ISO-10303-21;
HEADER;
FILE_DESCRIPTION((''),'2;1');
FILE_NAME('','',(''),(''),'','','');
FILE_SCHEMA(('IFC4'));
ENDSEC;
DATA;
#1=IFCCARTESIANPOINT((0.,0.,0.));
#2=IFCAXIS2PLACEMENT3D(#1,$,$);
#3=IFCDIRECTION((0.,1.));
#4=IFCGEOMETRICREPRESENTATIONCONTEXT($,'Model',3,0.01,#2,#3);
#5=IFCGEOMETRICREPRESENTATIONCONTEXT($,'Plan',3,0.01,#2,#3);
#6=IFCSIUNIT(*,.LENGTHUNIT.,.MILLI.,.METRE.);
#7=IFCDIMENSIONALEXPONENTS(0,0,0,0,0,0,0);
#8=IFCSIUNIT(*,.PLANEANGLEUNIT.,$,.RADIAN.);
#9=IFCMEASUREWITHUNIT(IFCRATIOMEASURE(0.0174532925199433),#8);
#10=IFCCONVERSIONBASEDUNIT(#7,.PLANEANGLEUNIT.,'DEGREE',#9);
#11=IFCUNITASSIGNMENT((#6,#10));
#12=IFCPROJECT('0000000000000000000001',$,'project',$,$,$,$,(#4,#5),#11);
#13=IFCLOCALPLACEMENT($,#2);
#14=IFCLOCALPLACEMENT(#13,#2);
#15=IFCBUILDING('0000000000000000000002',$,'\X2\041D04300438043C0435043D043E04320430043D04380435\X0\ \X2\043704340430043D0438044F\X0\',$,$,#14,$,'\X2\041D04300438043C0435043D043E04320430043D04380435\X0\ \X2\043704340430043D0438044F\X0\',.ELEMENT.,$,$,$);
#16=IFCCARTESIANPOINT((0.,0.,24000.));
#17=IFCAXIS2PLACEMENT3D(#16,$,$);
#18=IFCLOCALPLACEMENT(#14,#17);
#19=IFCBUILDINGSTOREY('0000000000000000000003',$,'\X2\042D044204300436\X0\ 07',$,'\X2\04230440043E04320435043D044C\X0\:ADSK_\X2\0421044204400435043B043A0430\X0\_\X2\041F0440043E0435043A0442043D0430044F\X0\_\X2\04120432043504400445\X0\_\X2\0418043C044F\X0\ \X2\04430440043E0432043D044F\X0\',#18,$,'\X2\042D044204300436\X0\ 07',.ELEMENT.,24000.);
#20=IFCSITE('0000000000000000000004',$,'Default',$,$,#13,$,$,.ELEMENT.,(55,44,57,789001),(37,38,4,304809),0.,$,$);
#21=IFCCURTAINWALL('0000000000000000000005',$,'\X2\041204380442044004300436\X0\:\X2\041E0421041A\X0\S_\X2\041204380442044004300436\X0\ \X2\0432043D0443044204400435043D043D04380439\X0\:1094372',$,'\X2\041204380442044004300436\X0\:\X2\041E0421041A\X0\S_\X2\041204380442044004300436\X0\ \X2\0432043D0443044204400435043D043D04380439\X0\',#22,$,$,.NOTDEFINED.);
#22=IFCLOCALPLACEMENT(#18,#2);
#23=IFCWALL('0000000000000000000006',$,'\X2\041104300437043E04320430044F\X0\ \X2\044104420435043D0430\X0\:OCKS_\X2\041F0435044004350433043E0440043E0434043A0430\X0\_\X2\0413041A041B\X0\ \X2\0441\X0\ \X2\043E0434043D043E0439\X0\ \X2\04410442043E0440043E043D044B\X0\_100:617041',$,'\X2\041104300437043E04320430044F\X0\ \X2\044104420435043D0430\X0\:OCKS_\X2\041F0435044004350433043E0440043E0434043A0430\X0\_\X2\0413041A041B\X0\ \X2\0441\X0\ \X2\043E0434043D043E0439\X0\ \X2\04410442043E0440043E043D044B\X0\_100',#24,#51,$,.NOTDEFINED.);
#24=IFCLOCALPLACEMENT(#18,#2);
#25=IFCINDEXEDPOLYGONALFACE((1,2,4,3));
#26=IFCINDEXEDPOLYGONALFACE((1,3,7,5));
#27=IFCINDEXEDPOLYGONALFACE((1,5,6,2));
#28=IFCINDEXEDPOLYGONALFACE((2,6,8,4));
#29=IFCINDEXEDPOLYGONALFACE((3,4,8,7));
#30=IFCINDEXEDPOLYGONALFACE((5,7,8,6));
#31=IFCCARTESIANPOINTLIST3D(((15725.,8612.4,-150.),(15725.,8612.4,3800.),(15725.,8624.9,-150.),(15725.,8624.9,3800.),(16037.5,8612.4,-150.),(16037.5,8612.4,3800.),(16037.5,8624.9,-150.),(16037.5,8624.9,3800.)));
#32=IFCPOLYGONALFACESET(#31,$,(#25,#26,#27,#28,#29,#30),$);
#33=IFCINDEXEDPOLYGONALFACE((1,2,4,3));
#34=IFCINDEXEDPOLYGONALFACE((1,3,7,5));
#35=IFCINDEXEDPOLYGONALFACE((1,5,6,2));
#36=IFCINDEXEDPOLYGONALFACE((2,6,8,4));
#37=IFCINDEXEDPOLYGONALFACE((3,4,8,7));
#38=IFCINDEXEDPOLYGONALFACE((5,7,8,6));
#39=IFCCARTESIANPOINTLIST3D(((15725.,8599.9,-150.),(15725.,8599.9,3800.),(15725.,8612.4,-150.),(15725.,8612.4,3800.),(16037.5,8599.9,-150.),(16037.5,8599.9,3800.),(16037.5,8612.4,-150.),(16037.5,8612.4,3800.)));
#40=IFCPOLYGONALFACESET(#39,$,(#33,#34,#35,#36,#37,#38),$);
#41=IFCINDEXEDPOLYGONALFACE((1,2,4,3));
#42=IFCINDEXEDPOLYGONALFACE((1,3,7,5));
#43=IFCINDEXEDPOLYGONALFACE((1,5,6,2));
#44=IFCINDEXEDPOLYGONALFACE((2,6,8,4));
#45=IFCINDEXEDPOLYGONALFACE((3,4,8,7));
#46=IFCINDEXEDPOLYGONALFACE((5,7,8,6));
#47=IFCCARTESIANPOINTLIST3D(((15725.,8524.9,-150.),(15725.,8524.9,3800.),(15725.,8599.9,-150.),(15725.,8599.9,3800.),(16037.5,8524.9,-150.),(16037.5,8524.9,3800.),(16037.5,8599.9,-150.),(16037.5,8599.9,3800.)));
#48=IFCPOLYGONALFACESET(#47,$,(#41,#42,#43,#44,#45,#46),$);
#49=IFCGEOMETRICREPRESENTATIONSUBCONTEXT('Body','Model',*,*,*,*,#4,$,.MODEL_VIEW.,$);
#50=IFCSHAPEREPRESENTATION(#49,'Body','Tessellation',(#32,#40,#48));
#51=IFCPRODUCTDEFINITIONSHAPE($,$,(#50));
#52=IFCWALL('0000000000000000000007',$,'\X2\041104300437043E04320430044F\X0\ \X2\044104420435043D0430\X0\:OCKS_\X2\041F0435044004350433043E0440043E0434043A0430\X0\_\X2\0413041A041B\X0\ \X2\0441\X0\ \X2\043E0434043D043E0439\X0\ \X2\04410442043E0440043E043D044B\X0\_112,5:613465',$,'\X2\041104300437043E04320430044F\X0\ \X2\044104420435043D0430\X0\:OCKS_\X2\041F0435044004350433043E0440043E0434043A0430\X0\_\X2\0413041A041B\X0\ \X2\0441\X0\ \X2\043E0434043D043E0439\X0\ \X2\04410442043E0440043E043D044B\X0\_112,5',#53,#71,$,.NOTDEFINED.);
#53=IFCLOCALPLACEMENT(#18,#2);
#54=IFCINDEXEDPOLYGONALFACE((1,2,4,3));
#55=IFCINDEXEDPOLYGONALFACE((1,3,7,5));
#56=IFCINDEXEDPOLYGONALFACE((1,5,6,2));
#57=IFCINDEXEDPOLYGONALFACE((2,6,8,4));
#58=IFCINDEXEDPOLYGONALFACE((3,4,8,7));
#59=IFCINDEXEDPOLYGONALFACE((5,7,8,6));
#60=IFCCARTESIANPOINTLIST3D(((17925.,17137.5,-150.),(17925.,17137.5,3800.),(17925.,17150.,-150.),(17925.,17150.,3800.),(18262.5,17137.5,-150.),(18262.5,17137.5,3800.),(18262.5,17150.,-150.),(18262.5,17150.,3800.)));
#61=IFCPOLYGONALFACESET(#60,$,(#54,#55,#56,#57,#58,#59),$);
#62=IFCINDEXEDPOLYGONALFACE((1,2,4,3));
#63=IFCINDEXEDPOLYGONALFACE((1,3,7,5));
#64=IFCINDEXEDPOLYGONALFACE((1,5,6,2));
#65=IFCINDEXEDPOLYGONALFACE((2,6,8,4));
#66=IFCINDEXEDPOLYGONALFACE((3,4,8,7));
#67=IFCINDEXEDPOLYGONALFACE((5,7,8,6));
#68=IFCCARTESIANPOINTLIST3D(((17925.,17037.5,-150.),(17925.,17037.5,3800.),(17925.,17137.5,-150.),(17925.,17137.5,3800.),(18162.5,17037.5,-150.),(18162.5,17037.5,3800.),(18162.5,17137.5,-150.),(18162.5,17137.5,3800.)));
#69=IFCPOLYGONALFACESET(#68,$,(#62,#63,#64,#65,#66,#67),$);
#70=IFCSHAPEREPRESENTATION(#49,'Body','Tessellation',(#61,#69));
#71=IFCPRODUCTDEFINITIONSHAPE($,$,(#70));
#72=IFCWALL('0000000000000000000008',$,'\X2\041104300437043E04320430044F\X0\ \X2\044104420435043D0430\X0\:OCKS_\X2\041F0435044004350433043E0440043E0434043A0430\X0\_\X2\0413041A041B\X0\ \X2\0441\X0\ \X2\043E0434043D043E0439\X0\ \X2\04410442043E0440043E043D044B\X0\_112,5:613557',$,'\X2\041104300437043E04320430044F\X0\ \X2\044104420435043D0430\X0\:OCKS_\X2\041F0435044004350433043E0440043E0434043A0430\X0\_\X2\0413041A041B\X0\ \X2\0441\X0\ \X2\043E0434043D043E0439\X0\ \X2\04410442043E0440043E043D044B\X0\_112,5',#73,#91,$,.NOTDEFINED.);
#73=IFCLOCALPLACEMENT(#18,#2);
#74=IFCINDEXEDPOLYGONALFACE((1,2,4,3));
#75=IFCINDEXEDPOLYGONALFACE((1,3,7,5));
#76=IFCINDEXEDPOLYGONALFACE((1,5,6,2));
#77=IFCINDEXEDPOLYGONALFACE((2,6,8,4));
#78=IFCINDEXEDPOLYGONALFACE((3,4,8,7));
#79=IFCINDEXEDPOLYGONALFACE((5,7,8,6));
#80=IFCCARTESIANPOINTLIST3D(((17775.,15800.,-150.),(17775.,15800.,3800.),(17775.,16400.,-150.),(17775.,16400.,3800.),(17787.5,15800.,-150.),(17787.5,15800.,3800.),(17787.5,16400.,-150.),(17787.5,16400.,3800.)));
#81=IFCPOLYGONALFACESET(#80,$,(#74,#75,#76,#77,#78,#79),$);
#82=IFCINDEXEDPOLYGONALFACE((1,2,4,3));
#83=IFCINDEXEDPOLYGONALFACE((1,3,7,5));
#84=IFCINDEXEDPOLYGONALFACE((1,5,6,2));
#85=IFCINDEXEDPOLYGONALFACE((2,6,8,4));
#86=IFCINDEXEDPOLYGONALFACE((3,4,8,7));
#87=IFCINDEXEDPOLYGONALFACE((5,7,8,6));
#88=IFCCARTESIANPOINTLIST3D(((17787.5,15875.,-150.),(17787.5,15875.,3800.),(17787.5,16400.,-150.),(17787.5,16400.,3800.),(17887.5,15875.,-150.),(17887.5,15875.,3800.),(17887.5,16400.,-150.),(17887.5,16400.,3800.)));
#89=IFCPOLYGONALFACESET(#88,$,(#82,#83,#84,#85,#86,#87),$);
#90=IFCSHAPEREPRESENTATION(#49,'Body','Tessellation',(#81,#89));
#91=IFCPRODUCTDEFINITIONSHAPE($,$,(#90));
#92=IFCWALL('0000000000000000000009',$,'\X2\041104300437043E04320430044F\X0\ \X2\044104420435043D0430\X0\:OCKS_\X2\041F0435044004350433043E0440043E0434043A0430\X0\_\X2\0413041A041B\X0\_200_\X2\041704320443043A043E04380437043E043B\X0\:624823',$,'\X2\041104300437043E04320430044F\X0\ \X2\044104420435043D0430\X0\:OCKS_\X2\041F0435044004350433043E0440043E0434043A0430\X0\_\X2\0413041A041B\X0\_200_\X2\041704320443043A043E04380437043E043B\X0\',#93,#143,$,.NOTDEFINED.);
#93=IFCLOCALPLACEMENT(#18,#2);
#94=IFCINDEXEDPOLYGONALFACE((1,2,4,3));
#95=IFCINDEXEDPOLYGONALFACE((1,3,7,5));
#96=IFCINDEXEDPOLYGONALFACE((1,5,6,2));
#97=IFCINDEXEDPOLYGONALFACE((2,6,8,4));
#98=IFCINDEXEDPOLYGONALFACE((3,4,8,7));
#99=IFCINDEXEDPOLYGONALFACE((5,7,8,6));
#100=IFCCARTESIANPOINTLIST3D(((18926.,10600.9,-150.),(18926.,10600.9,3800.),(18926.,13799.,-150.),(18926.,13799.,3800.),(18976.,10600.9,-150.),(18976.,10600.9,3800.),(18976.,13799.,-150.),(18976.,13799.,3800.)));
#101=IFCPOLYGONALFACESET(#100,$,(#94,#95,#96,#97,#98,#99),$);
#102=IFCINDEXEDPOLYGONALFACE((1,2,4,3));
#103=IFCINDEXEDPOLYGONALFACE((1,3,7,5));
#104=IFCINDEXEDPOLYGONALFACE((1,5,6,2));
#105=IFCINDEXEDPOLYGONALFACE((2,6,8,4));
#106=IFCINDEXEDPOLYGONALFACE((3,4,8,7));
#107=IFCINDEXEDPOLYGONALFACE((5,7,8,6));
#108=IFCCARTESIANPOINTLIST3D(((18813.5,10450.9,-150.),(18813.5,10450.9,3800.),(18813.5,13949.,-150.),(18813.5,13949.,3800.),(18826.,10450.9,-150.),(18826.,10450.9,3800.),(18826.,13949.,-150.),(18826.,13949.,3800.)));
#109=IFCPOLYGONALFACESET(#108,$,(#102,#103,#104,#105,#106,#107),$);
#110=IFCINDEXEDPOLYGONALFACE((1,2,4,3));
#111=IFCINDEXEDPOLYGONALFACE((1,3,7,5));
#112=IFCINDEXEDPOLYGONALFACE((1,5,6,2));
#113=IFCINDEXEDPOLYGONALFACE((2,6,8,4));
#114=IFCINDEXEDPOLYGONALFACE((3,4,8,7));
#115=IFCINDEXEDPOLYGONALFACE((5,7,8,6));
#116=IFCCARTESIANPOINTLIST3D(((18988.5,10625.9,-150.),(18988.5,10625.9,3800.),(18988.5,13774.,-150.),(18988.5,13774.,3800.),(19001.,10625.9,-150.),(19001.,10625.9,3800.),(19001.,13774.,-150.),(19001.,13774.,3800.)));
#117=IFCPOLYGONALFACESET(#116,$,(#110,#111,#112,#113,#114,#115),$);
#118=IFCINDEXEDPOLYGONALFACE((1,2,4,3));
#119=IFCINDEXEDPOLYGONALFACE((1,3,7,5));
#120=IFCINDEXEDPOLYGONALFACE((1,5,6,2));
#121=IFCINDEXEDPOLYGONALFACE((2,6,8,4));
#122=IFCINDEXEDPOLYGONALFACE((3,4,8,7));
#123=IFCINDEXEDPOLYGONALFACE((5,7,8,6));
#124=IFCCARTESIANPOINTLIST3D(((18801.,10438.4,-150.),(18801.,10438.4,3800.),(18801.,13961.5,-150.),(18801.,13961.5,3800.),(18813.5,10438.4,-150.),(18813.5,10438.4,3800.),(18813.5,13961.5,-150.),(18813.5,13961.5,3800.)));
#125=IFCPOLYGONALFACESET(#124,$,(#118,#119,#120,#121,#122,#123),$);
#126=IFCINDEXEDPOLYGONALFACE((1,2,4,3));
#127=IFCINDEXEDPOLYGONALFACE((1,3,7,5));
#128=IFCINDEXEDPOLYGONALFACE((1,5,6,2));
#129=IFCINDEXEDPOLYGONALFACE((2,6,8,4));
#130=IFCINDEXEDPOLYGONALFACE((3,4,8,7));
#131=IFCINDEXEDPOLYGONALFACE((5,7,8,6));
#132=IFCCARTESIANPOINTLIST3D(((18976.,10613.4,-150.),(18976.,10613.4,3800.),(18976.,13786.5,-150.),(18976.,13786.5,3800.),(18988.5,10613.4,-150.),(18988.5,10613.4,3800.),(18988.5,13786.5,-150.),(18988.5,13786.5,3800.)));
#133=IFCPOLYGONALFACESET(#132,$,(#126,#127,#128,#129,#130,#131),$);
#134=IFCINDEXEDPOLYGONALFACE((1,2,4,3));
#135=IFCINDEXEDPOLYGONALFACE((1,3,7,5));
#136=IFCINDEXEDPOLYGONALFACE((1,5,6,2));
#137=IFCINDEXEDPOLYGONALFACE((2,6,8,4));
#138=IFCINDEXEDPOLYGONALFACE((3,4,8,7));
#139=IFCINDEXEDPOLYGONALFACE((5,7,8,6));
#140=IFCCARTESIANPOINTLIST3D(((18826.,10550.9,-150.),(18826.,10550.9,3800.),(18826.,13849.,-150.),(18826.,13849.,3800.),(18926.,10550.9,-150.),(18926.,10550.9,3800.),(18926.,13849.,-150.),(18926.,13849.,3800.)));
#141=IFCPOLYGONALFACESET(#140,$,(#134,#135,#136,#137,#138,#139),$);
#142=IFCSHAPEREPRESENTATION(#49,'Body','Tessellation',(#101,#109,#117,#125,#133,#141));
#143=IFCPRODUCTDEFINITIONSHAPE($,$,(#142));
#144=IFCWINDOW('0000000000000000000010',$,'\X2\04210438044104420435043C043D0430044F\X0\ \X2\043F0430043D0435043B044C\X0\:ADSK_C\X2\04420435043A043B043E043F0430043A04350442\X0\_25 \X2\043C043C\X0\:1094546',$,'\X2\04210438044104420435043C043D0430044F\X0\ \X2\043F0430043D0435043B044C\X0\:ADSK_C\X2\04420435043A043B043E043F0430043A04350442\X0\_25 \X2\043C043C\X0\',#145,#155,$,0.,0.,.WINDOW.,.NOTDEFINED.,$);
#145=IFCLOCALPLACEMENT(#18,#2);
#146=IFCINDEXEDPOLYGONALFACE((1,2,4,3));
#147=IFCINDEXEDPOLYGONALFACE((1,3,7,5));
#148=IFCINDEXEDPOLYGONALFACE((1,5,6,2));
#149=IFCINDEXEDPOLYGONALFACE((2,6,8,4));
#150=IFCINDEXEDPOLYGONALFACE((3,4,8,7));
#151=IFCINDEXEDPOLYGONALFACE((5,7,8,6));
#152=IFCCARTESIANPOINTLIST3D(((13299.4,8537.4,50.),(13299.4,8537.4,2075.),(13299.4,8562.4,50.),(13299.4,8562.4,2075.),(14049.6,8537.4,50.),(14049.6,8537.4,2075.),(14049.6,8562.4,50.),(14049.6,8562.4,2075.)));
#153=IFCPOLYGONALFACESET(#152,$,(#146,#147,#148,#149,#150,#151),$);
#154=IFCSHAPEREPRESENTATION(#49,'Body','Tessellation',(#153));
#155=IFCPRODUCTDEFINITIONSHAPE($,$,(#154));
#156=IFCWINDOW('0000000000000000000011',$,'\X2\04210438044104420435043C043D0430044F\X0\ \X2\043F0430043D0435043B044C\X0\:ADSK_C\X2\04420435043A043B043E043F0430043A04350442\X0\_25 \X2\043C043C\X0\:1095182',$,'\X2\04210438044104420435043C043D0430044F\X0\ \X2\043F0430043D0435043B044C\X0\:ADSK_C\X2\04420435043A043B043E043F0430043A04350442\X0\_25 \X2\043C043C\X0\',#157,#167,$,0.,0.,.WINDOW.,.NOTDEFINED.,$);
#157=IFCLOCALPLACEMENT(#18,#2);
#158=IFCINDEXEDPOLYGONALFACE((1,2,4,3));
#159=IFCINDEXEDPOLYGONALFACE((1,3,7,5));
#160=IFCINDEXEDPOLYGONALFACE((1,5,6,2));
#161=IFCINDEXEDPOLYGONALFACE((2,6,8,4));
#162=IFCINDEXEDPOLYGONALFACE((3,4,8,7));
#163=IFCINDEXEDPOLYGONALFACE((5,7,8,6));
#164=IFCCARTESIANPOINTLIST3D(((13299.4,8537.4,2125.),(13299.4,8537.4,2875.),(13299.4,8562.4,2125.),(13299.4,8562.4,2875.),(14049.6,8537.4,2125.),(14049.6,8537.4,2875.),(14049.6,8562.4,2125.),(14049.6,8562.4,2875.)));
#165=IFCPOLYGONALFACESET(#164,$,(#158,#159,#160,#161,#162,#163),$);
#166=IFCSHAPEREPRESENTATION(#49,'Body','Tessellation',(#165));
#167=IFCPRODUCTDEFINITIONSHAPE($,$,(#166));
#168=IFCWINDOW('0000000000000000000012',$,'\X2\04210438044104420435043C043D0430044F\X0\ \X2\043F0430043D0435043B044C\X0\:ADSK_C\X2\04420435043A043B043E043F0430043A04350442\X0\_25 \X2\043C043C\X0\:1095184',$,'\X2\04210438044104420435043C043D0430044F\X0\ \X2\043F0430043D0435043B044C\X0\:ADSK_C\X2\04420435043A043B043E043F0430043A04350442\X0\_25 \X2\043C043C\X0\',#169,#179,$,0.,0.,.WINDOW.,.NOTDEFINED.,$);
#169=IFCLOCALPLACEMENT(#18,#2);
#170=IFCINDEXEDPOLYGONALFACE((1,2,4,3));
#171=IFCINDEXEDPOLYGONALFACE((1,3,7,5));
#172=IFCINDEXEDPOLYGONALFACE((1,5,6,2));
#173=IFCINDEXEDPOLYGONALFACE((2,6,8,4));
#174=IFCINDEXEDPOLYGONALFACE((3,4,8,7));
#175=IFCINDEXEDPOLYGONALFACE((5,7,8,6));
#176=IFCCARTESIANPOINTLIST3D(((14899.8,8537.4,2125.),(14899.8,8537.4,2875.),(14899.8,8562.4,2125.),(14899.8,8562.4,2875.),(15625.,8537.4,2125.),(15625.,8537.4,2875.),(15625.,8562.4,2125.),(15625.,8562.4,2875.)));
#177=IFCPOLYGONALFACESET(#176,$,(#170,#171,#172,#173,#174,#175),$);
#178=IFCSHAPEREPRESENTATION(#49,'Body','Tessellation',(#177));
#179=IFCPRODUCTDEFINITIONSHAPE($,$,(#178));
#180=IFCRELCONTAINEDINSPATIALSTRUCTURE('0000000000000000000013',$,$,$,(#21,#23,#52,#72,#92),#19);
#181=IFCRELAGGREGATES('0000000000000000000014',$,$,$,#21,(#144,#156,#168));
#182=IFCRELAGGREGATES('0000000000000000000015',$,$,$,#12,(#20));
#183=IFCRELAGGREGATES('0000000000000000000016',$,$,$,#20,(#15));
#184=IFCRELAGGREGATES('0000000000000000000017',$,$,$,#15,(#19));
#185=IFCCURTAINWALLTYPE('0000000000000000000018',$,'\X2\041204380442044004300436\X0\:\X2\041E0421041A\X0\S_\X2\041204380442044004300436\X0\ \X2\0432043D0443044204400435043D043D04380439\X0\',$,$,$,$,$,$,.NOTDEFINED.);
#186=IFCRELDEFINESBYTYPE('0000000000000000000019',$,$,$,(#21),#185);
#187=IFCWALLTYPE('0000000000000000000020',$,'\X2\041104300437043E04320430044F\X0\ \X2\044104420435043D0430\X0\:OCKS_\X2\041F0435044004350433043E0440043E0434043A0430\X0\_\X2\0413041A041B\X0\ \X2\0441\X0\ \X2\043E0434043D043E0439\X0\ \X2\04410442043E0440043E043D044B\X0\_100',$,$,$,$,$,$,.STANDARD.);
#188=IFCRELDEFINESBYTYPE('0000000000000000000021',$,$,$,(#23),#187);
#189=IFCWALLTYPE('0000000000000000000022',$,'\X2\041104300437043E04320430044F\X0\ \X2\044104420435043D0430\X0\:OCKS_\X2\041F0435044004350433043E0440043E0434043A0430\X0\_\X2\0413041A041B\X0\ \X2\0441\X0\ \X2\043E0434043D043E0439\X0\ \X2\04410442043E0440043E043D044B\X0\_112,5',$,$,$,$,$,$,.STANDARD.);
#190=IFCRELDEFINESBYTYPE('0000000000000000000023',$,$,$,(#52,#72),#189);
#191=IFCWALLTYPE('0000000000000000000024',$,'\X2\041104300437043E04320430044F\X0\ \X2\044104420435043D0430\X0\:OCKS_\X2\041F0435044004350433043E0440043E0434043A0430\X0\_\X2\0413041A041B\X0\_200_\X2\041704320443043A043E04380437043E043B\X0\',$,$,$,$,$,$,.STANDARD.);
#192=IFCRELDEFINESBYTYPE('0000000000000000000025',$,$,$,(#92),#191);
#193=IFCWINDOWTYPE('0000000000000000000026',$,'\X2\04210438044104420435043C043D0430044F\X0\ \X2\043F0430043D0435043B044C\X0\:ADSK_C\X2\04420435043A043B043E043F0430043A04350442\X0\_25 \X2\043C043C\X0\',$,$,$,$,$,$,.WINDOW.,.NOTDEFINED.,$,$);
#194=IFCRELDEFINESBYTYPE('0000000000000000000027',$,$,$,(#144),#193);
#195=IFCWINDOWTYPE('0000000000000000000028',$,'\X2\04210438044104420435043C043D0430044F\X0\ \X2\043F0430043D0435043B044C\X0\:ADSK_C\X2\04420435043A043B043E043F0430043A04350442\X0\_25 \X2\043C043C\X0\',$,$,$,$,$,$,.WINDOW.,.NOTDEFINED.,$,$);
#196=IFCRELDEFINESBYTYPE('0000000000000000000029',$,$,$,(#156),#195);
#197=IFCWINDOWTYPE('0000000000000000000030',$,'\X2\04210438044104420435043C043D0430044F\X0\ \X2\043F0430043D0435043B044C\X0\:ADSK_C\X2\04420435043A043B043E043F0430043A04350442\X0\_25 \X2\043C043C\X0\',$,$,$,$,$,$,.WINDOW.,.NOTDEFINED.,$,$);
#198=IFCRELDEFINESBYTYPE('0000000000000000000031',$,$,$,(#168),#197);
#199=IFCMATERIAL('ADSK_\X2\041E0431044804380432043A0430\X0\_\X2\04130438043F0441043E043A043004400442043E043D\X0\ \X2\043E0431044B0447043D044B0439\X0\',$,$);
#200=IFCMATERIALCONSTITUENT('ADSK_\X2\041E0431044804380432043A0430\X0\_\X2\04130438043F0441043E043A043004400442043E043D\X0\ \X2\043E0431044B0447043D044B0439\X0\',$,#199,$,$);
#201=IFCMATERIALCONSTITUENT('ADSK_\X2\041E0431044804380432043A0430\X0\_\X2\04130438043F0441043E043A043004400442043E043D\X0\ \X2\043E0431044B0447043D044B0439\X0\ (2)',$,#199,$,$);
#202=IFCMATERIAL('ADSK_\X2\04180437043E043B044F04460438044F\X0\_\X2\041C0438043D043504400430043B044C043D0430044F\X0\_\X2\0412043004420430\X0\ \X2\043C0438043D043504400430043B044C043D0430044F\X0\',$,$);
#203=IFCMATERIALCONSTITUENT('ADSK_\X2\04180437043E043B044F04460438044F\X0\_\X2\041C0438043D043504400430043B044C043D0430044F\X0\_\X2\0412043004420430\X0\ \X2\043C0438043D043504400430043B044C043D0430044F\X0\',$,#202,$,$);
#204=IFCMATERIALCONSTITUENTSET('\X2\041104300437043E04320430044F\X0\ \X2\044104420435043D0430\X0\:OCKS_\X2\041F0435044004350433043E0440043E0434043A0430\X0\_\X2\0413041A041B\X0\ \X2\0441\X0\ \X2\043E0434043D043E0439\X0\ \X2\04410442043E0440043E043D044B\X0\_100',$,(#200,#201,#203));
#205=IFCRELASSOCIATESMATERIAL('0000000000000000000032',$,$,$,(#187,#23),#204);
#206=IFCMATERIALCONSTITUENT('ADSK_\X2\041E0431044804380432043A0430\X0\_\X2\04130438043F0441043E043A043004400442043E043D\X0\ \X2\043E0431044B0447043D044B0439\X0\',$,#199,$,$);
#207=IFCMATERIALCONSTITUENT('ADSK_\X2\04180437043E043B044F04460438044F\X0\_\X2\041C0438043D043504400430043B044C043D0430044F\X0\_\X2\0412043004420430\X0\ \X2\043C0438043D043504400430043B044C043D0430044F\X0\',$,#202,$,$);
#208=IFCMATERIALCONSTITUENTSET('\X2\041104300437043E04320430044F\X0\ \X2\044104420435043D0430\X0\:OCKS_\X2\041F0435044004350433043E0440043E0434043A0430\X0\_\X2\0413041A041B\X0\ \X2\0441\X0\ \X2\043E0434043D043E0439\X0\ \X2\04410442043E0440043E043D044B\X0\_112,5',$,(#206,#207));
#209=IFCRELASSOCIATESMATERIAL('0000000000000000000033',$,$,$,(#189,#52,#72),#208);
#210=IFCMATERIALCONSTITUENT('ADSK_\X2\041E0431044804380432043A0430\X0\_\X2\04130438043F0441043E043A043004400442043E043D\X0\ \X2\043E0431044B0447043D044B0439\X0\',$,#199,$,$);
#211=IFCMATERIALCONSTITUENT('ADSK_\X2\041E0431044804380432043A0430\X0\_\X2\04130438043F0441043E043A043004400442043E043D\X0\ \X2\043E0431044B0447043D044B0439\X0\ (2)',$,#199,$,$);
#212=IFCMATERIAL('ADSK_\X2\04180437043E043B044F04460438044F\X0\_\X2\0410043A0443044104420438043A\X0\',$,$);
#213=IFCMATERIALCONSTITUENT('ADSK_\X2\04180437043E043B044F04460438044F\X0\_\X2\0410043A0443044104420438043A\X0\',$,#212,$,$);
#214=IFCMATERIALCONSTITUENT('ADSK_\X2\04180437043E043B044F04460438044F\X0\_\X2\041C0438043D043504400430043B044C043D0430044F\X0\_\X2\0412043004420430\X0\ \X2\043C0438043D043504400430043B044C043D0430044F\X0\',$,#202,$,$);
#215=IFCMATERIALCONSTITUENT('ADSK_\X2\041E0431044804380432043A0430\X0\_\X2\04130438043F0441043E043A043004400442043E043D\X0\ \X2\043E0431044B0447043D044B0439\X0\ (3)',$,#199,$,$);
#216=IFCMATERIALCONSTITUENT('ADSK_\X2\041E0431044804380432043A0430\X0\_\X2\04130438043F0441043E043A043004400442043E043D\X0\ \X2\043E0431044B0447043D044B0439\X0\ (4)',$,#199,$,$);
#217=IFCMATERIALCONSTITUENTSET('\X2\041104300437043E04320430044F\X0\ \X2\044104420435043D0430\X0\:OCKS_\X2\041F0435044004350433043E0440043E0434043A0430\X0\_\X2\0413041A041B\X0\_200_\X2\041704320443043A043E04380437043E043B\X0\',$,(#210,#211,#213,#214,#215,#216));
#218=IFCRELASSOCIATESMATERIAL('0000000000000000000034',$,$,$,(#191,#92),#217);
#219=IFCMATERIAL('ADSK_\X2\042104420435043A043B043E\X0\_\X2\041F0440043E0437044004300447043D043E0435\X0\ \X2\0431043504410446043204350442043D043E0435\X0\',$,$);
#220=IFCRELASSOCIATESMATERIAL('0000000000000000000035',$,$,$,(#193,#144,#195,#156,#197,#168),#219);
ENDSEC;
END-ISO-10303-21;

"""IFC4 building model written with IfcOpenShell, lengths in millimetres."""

from ifc_helpers import new_model, entity, si_unit, converted_unit, direction, frame, origin, place, context, subcontext, project, spatial, indexed_curve, outline, extrude, source, transform, mapped, material, constituent, constituent_set, type_object, type_shapes, element, aggregate, save


model = new_model("IFC4")

# Units and contexts
model_context = context("Model", 3, precision=0.01, world=origin(), true_north=direction((0.0, 1.0)))
plan_context = context("Plan", 3, precision=0.01, world=origin(), true_north=direction((0.0, 1.0)))
body_context = subcontext(model_context, "Body", "Model", "MODEL_VIEW")
ifc_project = project(units=[si_unit("LENGTHUNIT", "METRE", prefix="MILLI"), converted_unit("PLANEANGLEUNIT", "DEGREE", entity("IfcRatioMeasure", 0.0174532925199433), si_unit("PLANEANGLEUNIT", "RADIAN"), dimensions=[0, 0, 0, 0, 0, 0, 0])], contexts=[model_context, plan_context])

# Site, building, storey
site_placement = place(None, frame((0.0, 0.0, 0.0)))
site = spatial("IfcSite", under=ifc_project, at=site_placement, Name="Default", CompositionType="ELEMENT", RefLatitude=(55, 44, 57, 789001), RefLongitude=(37, 38, 4, 304809), RefElevation=0.0)
building_placement = place(site_placement, origin())
building = spatial("IfcBuilding", under=site, at=building_placement, Name="Наименование здания", LongName="Наименование здания", CompositionType="ELEMENT")
storey_placement = place(building_placement, frame((0.0, 0.0, 24000.0)))
storey = spatial("IfcBuildingStorey", under=building, at=storey_placement, Name="Этаж 07", ObjectType="Уровень:ADSK_Стрелка_Проектная_Вверх_Имя уровня", LongName="Этаж 07", CompositionType="ELEMENT", Elevation=24000.0)

# Curtain wall
curtain_wall_type = type_object("IfcCurtainWallType", Name="Витраж:ОСКS_Витраж внутренний", PredefinedType="NOTDEFINED")
curtain_wall_placement = place(storey_placement, frame((0.0, 0.0, -24000.0)))
curtain_wall = element("IfcCurtainWall", 1, at=curtain_wall_placement, inside=storey, type_object=curtain_wall_type, Name="Витраж:ОСКS_Витраж внутренний:1094372", ObjectType="Витраж:ОСКS_Витраж внутренний", PredefinedType="NOTDEFINED")

# Shared definitions
ifc_material_1 = material(Name="ADSK_Обшивка_Гипсокартон обычный")
ifc_material_2 = material(Name="ADSK_Изоляция_Минеральная_Вата минеральная")

# Walls
ifc_constituent_1 = constituent(ifc_material_1, Name="ADSK_Обшивка_Гипсокартон обычный")
ifc_constituent_2 = constituent(ifc_material_1, Name="ADSK_Обшивка_Гипсокартон обычный (2)")
ifc_constituent_3 = constituent(ifc_material_2, Name="ADSK_Изоляция_Минеральная_Вата минеральная")
ifc_constituent_set_1 = constituent_set(constituents=[ifc_constituent_1, ifc_constituent_2, ifc_constituent_3], Name="Базовая стена:OCKS_Перегородка_ГКЛ с одной стороны_100")
wall_type_1 = type_object("IfcWallType", Name="Базовая стена:OCKS_Перегородка_ГКЛ с одной стороны_100", PredefinedType="STANDARD", material=ifc_constituent_set_1)
wall_1_placement = place(storey_placement, frame((15725.0, 8574.9, -150.0)))
element("IfcWall", 2, at=wall_1_placement, inside=storey, type_object=wall_type_1, material=ifc_constituent_set_1, Name="Базовая стена:OCKS_Перегородка_ГКЛ с одной стороны_100:617041", ObjectType="Базовая стена:OCKS_Перегородка_ГКЛ с одной стороны_100", PredefinedType="NOTDEFINED", context=body_context, shape_type="SweptSolid", body=[
    extrude(outline(indexed_curve([(-6.3, -156.3), (6.2, -156.3), (6.2, 156.3), (-6.2, 156.3), (-6.3, -156.3)], self_intersect=False)), frame((156.3, 43.7, 0.0), z_axis=(0.0, 0.0, 1.0), x_axis=(0.0, -1.0, 0.0)), (0.0, 0.0, 1.0), 3950.0),
    extrude(outline(indexed_curve([(-156.3, -6.3), (156.3, -6.3), (156.3, 6.3), (-156.3, 6.3), (-156.3, -6.3)], self_intersect=False)), frame((156.3, 31.3, 0.0)), (0.0, 0.0, 1.0), 3950.0),
    extrude(outline(indexed_curve([(-37.5, -156.3), (37.5, -156.3), (37.5, 156.3), (-37.5, 156.3), (-37.5, -156.3)], self_intersect=False)), frame((156.3, -12.5, 0.0), z_axis=(0.0, 0.0, 1.0), x_axis=(0.0, 1.0, 0.0)), (0.0, 0.0, 1.0), 3950.0),
])
ifc_constituent_4 = constituent(ifc_material_1, Name="ADSK_Обшивка_Гипсокартон обычный")
ifc_constituent_5 = constituent(ifc_material_2, Name="ADSK_Изоляция_Минеральная_Вата минеральная")
ifc_constituent_set_2 = constituent_set(constituents=[ifc_constituent_4, ifc_constituent_5], Name="Базовая стена:OCKS_Перегородка_ГКЛ с одной стороны_112,5")
wall_type_2 = type_object("IfcWallType", Name="Базовая стена:OCKS_Перегородка_ГКЛ с одной стороны_112,5", PredefinedType="STANDARD", material=ifc_constituent_set_2)
wall_2_placement = place(storey_placement, frame((18162.5, 17093.7, -150.0), z_axis=(0.0, 0.0, 1.0), x_axis=(-1.0, 0.0, 0.0)))
element("IfcWall", 3, at=wall_2_placement, inside=storey, type_object=wall_type_2, material=ifc_constituent_set_2, Name="Базовая стена:OCKS_Перегородка_ГКЛ с одной стороны_112,5:613465", ObjectType="Базовая стена:OCKS_Перегородка_ГКЛ с одной стороны_112,5", PredefinedType="NOTDEFINED", context=body_context, shape_type="SweptSolid", body=[
    extrude(outline(indexed_curve([(-6.2, -168.7), (6.3, -168.7), (6.3, 168.7), (-6.2, 168.7), (-6.2, -168.7)], self_intersect=False)), frame((68.7, -50.0, 0.0), z_axis=(0.0, 0.0, 1.0), x_axis=(0.0, 1.0, 0.0)), (0.0, 0.0, 1.0), 3950.0),
    extrude(outline(indexed_curve([(-50.0, -118.7), (50.0, -118.7), (50.0, 118.7), (-50.0, 118.7), (-50.0, -118.7)], self_intersect=False)), frame((118.7, 6.2, 0.0), z_axis=(0.0, 0.0, 1.0), x_axis=(0.0, -1.0, 0.0)), (0.0, 0.0, 1.0), 3950.0),
])
wall_3_placement = place(storey_placement, frame((17831.3, 15875.0, -150.0), z_axis=(0.0, 0.0, 1.0), x_axis=(0.0, 1.0, 0.0)))
element("IfcWall", 4, at=wall_3_placement, inside=storey, type_object=wall_type_2, material=ifc_constituent_set_2, Name="Базовая стена:OCKS_Перегородка_ГКЛ с одной стороны_112,5:613557", ObjectType="Базовая стена:OCKS_Перегородка_ГКЛ с одной стороны_112,5", PredefinedType="NOTDEFINED", context=body_context, shape_type="SweptSolid", body=[
    extrude(outline(indexed_curve([(-6.3, -300.0), (6.2, -300.0), (6.2, 300.0), (-6.3, 300.0), (-6.3, -300.0)], self_intersect=False)), frame((225.0, 50.0, 0.0), z_axis=(0.0, 0.0, 1.0), x_axis=(0.0, -1.0, 0.0)), (0.0, 0.0, 1.0), 3950.0),
    extrude(outline(indexed_curve([(-50.0, -262.5), (50.0, -262.5), (50.0, 262.5), (-50.0, 262.5), (-50.0, -262.5)], self_intersect=False)), frame((262.5, -6.3, 0.0), z_axis=(0.0, 0.0, 1.0), x_axis=(0.0, 1.0, 0.0)), (0.0, 0.0, 1.0), 3950.0),
])

# Wall
ifc_constituent_6 = constituent(ifc_material_1, Name="ADSK_Обшивка_Гипсокартон обычный")
ifc_constituent_7 = constituent(ifc_material_1, Name="ADSK_Обшивка_Гипсокартон обычный (2)")
ifc_material_3 = material(Name="ADSK_Изоляция_Акустик")
ifc_constituent_8 = constituent(ifc_material_3, Name="ADSK_Изоляция_Акустик")
ifc_constituent_9 = constituent(ifc_material_2, Name="ADSK_Изоляция_Минеральная_Вата минеральная")
ifc_constituent_10 = constituent(ifc_material_1, Name="ADSK_Обшивка_Гипсокартон обычный (3)")
ifc_constituent_11 = constituent(ifc_material_1, Name="ADSK_Обшивка_Гипсокартон обычный (4)")
ifc_constituent_set_3 = constituent_set(constituents=[ifc_constituent_6, ifc_constituent_7, ifc_constituent_8, ifc_constituent_9, ifc_constituent_10, ifc_constituent_11], Name="Базовая стена:OCKS_Перегородка_ГКЛ_200_Звукоизол")
wall_type_3 = type_object("IfcWallType", Name="Базовая стена:OCKS_Перегородка_ГКЛ_200_Звукоизол", PredefinedType="STANDARD", material=ifc_constituent_set_3)
wall_4_placement = place(storey_placement, frame((18901.0, 10625.9, -150.0), z_axis=(0.0, 0.0, 1.0), x_axis=(0.0, 1.0, 0.0)))
element("IfcWall", 5, at=wall_4_placement, inside=storey, type_object=wall_type_3, material=ifc_constituent_set_3, Name="Базовая стена:OCKS_Перегородка_ГКЛ_200_Звукоизол:624823", ObjectType="Базовая стена:OCKS_Перегородка_ГКЛ_200_Звукоизол", PredefinedType="NOTDEFINED", context=body_context, shape_type="SweptSolid", body=[
    extrude(outline(indexed_curve([(-1599.0, -25.0), (1599.0, -25.0), (1599.0, 25.0), (-1599.0, 25.0), (-1599.0, -25.0)], self_intersect=False)), frame((1574.0, -50.0, 0.0)), (0.0, 0.0, 1.0), 3950.0),
    extrude(outline(indexed_curve([(-1749.0, -6.3), (1749.0, -6.3), (1749.0, 6.2), (-1749.0, 6.2), (-1749.0, -6.3)], self_intersect=False)), frame((1574.0, 81.3, 0.0)), (0.0, 0.0, 1.0), 3950.0),
    extrude(outline(indexed_curve([(-6.3, -1574.0), (6.2, -1574.0), (6.3, 1574.0), (-6.2, 1574.0), (-6.3, -1574.0)], self_intersect=False)), frame((1574.0, -93.8, 0.0), z_axis=(0.0, 0.0, 1.0), x_axis=(0.0, 1.0, 0.0)), (0.0, 0.0, 1.0), 3950.0),
    extrude(outline(indexed_curve([(-6.3, -1761.5), (6.2, -1761.5), (6.3, 1761.5), (-6.2, 1761.5), (-6.3, -1761.5)], self_intersect=False)), frame((1574.0, 93.7, 0.0), z_axis=(0.0, 0.0, 1.0), x_axis=(0.0, -1.0, 0.0)), (0.0, 0.0, 1.0), 3950.0),
    extrude(outline(indexed_curve([(-1586.5, -6.2), (1586.5, -6.2), (1586.5, 6.3), (-1586.5, 6.3), (-1586.5, -6.2)], self_intersect=False)), frame((1574.0, -81.3, 0.0)), (0.0, 0.0, 1.0), 3950.0),
    extrude(outline(indexed_curve([(-1649.0, -50.0), (1649.0, -50.0), (1649.0, 50.0), (-1649.0, 50.0), (-1649.0, -50.0)], self_intersect=False)), frame((1574.0, 25.0, 0.0)), (0.0, 0.0, 1.0), 3950.0),
])

# Windows
ifc_material_4 = material(Name="ADSK_Стекло_Прозрачное бесцветное")
window_type_1 = type_object("IfcWindowType", Name="Системная панель:ADSK_Cтеклопакет_25 мм", PartitioningType="NOTDEFINED", PredefinedType="WINDOW", material=ifc_material_4)
shared_shape_1 = source(origin(), body_context, "Body", "SweptSolid", [
    extrude(outline(indexed_curve([(-12.5, -375.1), (12.5, -375.1), (12.5, 375.1), (-12.5, 375.1), (-12.5, -375.1)], self_intersect=False)), frame((0.0, 0.0, 0.0), z_axis=(0.0, 0.0, 1.0), x_axis=(0.0, 1.0, 0.0)), (0.0, 0.0, 1.0), 2025.0),
])
type_shapes(window_type_1, [shared_shape_1])
window_1_placement = place(curtain_wall_placement, frame((13674.5, 8549.9, 24050.0)))
window_1 = element("IfcWindow", 6, at=window_1_placement, type_object=window_type_1, material=ifc_material_4, Name="Системная панель:ADSK_Cтеклопакет_25 мм:1094546", ObjectType="Системная панель:ADSK_Cтеклопакет_25 мм", OverallHeight=0.0, OverallWidth=0.0, PartitioningType="NOTDEFINED", PredefinedType="WINDOW", context=body_context, shape_type="MappedRepresentation", body=[
    mapped(shared_shape_1, transform((0.0, 0.0, 0.0), scale=1.0)),
])
window_type_2 = type_object("IfcWindowType", Name="Системная панель:ADSK_Cтеклопакет_25 мм", PartitioningType="NOTDEFINED", PredefinedType="WINDOW", material=ifc_material_4)
shared_shape_2 = source(origin(), body_context, "Body", "SweptSolid", [
    extrude(outline(indexed_curve([(-12.5, -375.1), (12.5, -375.1), (12.5, 375.1), (-12.5, 375.1), (-12.5, -375.1)], self_intersect=False)), frame((0.0, 0.0, 0.0), z_axis=(0.0, 0.0, 1.0), x_axis=(0.0, 1.0, 0.0)), (0.0, 0.0, 1.0), 750.0),
])
type_shapes(window_type_2, [shared_shape_2])
window_2_placement = place(curtain_wall_placement, frame((13674.5, 8549.9, 26125.0)))
window_2 = element("IfcWindow", 7, at=window_2_placement, type_object=window_type_2, material=ifc_material_4, Name="Системная панель:ADSK_Cтеклопакет_25 мм:1095182", ObjectType="Системная панель:ADSK_Cтеклопакет_25 мм", OverallHeight=0.0, OverallWidth=0.0, PartitioningType="NOTDEFINED", PredefinedType="WINDOW", context=body_context, shape_type="MappedRepresentation", body=[
    mapped(shared_shape_2, transform((0.0, 0.0, 0.0), scale=1.0)),
])
window_type_3 = type_object("IfcWindowType", Name="Системная панель:ADSK_Cтеклопакет_25 мм", PartitioningType="NOTDEFINED", PredefinedType="WINDOW", material=ifc_material_4)
shared_shape_3 = source(origin(), body_context, "Body", "SweptSolid", [
    extrude(outline(indexed_curve([(-12.5, -362.6), (12.5, -362.6), (12.5, 362.6), (-12.5, 362.6), (-12.5, -362.6)], self_intersect=False)), frame((0.0, 0.0, 0.0), z_axis=(0.0, 0.0, 1.0), x_axis=(0.0, 1.0, 0.0)), (0.0, 0.0, 1.0), 750.0),
])
type_shapes(window_type_3, [shared_shape_3])
window_3_placement = place(curtain_wall_placement, frame((15262.4, 8549.9, 26125.0)))
window_3 = element("IfcWindow", 8, at=window_3_placement, type_object=window_type_3, material=ifc_material_4, Name="Системная панель:ADSK_Cтеклопакет_25 мм:1095184", ObjectType="Системная панель:ADSK_Cтеклопакет_25 мм", OverallHeight=0.0, OverallWidth=0.0, PartitioningType="NOTDEFINED", PredefinedType="WINDOW", context=body_context, shape_type="MappedRepresentation", body=[
    mapped(shared_shape_3, transform((0.0, 0.0, 0.0), scale=1.0)),
])
aggregate(curtain_wall, [window_1, window_2, window_3])

save(model, "model.ifc")
